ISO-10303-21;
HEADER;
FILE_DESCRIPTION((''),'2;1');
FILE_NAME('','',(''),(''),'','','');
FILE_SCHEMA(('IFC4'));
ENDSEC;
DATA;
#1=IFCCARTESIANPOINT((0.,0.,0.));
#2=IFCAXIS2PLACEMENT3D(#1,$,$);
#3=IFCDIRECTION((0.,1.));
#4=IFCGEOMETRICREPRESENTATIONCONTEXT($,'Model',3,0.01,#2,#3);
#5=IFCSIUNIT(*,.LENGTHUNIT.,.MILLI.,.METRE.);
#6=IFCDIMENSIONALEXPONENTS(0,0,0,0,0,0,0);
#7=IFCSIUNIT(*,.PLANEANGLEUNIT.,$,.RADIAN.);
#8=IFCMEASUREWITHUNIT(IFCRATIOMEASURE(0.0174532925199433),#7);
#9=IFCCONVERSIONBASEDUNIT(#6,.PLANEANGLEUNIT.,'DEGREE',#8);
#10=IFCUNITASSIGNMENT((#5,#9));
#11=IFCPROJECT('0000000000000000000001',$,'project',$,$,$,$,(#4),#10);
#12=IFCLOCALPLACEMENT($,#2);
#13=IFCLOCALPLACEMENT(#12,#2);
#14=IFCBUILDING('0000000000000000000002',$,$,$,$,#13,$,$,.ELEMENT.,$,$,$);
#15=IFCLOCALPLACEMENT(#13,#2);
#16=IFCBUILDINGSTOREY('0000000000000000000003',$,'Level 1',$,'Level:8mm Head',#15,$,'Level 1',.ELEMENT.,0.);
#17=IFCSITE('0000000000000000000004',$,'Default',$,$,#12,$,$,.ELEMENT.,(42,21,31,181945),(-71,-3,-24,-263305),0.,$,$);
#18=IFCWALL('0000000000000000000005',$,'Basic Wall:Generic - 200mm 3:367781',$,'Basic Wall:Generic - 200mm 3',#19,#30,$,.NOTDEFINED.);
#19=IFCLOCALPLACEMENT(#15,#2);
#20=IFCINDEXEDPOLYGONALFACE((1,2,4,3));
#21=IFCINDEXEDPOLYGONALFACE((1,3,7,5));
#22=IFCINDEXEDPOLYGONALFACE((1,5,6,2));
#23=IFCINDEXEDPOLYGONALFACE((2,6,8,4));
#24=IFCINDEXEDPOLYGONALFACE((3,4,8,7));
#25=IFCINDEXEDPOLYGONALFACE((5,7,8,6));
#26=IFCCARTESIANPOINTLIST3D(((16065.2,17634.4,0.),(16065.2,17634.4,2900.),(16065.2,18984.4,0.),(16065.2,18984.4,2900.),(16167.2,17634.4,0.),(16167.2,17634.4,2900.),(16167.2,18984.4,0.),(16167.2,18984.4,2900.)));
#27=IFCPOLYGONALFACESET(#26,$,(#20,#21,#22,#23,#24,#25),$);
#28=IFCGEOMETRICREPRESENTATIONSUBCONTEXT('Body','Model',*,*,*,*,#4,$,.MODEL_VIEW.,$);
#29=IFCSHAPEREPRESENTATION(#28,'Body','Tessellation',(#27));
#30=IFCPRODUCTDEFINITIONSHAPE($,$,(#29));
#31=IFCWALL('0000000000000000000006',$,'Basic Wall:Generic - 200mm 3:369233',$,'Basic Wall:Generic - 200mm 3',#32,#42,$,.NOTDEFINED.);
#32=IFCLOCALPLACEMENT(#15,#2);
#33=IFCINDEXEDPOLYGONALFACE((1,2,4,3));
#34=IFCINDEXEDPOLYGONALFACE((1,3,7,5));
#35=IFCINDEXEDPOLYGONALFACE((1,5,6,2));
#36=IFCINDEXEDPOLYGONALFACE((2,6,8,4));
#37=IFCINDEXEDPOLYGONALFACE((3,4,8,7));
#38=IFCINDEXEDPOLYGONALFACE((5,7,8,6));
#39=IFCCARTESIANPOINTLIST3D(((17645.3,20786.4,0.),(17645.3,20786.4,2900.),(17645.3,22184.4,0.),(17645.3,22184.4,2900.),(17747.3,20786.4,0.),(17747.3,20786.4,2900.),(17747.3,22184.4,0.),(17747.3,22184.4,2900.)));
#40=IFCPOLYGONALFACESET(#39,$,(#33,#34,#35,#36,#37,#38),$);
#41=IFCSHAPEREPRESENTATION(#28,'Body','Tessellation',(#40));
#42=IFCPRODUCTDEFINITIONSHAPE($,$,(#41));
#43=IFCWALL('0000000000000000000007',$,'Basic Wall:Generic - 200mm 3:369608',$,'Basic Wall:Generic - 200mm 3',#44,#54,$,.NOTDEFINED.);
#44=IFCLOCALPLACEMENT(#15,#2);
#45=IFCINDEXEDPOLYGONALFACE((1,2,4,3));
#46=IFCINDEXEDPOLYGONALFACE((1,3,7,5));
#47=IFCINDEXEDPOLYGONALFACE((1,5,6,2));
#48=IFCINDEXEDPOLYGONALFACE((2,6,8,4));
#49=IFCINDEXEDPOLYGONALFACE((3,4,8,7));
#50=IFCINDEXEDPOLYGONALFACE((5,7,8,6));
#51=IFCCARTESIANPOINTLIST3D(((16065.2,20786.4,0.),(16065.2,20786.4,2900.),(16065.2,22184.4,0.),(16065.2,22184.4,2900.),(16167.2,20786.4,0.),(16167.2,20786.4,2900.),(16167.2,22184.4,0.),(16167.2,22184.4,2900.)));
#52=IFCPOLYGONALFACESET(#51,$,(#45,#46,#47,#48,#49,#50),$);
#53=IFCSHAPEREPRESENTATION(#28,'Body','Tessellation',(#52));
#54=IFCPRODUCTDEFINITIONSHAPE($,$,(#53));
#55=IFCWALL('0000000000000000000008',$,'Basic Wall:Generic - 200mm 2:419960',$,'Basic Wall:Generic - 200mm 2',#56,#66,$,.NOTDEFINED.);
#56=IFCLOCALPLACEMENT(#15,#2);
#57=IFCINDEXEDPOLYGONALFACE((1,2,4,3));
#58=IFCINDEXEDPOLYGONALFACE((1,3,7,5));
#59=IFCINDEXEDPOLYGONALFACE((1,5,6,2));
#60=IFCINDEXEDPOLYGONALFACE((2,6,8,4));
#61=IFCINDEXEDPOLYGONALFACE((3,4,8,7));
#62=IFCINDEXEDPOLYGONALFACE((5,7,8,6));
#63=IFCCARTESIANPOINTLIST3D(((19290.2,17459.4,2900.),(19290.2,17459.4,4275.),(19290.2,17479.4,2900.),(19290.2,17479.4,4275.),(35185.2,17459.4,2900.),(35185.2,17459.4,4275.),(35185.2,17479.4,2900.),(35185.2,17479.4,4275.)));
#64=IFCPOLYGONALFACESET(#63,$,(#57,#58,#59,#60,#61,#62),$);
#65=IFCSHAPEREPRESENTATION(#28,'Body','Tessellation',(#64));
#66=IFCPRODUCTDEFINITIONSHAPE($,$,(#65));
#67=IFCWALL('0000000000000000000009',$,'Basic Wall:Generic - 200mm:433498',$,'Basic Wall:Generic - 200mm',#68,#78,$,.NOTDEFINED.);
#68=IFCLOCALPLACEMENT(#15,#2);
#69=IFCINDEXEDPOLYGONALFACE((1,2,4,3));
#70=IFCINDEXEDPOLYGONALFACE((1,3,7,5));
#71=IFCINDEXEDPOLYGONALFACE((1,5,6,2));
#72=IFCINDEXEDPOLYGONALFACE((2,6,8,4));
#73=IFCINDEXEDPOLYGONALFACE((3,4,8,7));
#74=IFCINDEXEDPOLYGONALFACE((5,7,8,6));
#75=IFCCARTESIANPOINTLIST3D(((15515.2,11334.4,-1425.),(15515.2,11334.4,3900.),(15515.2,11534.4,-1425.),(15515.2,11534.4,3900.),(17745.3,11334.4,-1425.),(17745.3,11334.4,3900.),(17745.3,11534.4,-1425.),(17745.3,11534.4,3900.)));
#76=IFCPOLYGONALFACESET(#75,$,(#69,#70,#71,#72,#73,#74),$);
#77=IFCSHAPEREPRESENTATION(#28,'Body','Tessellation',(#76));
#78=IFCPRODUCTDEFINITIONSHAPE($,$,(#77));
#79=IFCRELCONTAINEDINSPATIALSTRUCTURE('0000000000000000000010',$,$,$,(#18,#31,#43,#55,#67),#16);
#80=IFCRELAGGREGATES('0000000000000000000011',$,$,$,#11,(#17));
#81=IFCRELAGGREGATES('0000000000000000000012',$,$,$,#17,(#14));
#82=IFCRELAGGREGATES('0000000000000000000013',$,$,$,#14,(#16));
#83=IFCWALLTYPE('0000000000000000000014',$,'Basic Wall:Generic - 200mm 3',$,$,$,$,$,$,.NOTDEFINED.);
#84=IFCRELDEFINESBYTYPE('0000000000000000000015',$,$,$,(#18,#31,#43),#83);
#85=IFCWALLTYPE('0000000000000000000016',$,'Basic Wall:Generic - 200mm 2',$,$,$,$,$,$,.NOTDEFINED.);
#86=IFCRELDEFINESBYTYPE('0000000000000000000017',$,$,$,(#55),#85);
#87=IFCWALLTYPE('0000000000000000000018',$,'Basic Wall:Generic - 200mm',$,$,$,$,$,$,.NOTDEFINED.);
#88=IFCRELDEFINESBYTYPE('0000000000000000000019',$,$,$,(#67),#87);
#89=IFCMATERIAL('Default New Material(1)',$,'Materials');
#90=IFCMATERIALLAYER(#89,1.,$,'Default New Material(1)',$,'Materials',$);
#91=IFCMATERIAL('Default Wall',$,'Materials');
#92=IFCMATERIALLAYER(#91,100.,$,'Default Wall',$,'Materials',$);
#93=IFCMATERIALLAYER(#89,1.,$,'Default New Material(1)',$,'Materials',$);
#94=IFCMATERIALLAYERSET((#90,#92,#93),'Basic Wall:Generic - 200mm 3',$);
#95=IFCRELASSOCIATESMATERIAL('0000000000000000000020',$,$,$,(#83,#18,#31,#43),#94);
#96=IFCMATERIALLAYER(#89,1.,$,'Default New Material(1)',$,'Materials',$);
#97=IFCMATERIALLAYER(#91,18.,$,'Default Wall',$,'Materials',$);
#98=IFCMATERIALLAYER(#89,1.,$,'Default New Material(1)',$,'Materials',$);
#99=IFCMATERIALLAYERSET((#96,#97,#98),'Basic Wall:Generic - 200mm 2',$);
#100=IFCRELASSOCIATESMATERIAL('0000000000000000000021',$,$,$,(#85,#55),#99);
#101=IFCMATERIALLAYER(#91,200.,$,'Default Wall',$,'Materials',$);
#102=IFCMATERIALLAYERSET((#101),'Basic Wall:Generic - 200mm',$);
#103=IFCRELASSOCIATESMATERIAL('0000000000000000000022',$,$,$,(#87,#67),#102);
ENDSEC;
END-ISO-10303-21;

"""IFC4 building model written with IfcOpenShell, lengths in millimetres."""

from ifc_helpers import new_model, entity, si_unit, converted_unit, direction, frame, origin, place, context, subcontext, project, spatial, indexed_curve, outline, extrude, material, layer, layer_set, type_object, element, save


model = new_model("IFC4")

# Units and contexts
model_context = context("Model", 3, precision=0.01, world=origin(), true_north=direction((0.0, 1.0)))
body_context = subcontext(model_context, "Body", "Model", "MODEL_VIEW")
ifc_project = project(units=[si_unit("LENGTHUNIT", "METRE", prefix="MILLI"), converted_unit("PLANEANGLEUNIT", "DEGREE", entity("IfcRatioMeasure", 0.0174532925199433), si_unit("PLANEANGLEUNIT", "RADIAN"), dimensions=[0, 0, 0, 0, 0, 0, 0])], contexts=[model_context])

# Site, building, storey
site_placement = place(None, origin())
site = spatial("IfcSite", under=ifc_project, at=site_placement, Name="Default", CompositionType="ELEMENT", RefLatitude=(42, 21, 31, 181945), RefLongitude=(-71, -3, -24, -263305), RefElevation=0.0)
building_placement = place(site_placement, origin())
building = spatial("IfcBuilding", under=site, at=building_placement, CompositionType="ELEMENT")
storey_placement = place(building_placement, origin())
storey = spatial("IfcBuildingStorey", under=building, at=storey_placement, Name="Level 1", ObjectType="Level:8mm Head", LongName="Level 1", CompositionType="ELEMENT", Elevation=0.0)

# Walls
ifc_material_1 = material(Name="Default Wall", Category="Materials")
ifc_material_2 = material(Name="Default New Material(1)", Category="Materials")
ifc_layer_1 = layer(ifc_material_2, 1.0, Name="Default New Material(1)", Category="Materials")
ifc_layer_2 = layer(ifc_material_1, 100.0, Name="Default Wall", Category="Materials")
ifc_layer_3 = layer(ifc_material_2, 1.0, Name="Default New Material(1)", Category="Materials")
ifc_layer_set_1 = layer_set([ifc_layer_1, ifc_layer_2, ifc_layer_3], Name="Basic Wall:Generic - 200mm 3")
wall_type_1 = type_object("IfcWallType", Name="Basic Wall:Generic - 200mm 3", PredefinedType="NOTDEFINED", material=ifc_layer_set_1)
wall_1_placement = place(storey_placement, frame((16116.2, 17634.4, 0.0), z_axis=(0.0, 0.0, 1.0), x_axis=(0.0, 1.0, 0.0)))
element("IfcWall", 1, at=wall_1_placement, inside=storey, type_object=wall_type_1, material=ifc_layer_set_1, Name="Basic Wall:Generic - 200mm 3:367781", ObjectType="Basic Wall:Generic - 200mm 3", PredefinedType="NOTDEFINED", context=body_context, shape_type="SweptSolid", body=[
    extrude(outline(indexed_curve([(1350.0, 51.0), (0.0, 51.0), (0.0, -51.0), (1350.0, -51.0), (1350.0, 51.0)], self_intersect=False)), origin(), (0.0, 0.0, 1.0), 2900.0),
])
wall_2_placement = place(storey_placement, frame((17696.3, 20786.4, 0.0), z_axis=(0.0, 0.0, 1.0), x_axis=(0.0, 1.0, 0.0)))
element("IfcWall", 2, at=wall_2_placement, inside=storey, type_object=wall_type_1, material=ifc_layer_set_1, Name="Basic Wall:Generic - 200mm 3:369233", ObjectType="Basic Wall:Generic - 200mm 3", PredefinedType="NOTDEFINED", context=body_context, shape_type="SweptSolid", body=[
    extrude(outline(indexed_curve([(1398.0, 51.0), (0.0, 51.0), (0.0, -51.0), (1398.0, -51.0), (1398.0, 51.0)], self_intersect=False)), origin(), (0.0, 0.0, 1.0), 2900.0),
])
wall_3_placement = place(storey_placement, frame((16116.2, 20786.4, 0.0), z_axis=(0.0, 0.0, 1.0), x_axis=(0.0, 1.0, 0.0)))
element("IfcWall", 3, at=wall_3_placement, inside=storey, type_object=wall_type_1, material=ifc_layer_set_1, Name="Basic Wall:Generic - 200mm 3:369608", ObjectType="Basic Wall:Generic - 200mm 3", PredefinedType="NOTDEFINED", context=body_context, shape_type="SweptSolid", body=[
    extrude(outline(indexed_curve([(1398.0, 51.0), (0.0, 51.0), (0.0, -51.0), (1398.0, -51.0), (1398.0, 51.0)], self_intersect=False)), origin(), (0.0, 0.0, 1.0), 2900.0),
])
ifc_layer_4 = layer(ifc_material_2, 1.0, Name="Default New Material(1)", Category="Materials")
ifc_layer_5 = layer(ifc_material_1, 18.0, Name="Default Wall", Category="Materials")
ifc_layer_6 = layer(ifc_material_2, 1.0, Name="Default New Material(1)", Category="Materials")
ifc_layer_set_2 = layer_set([ifc_layer_4, ifc_layer_5, ifc_layer_6], Name="Basic Wall:Generic - 200mm 2")
wall_type_2 = type_object("IfcWallType", Name="Basic Wall:Generic - 200mm 2", PredefinedType="NOTDEFINED", material=ifc_layer_set_2)
wall_4_placement = place(storey_placement, frame((19290.2, 17469.4, 2900.0)))
element("IfcWall", 4, at=wall_4_placement, inside=storey, type_object=wall_type_2, material=ifc_layer_set_2, Name="Basic Wall:Generic - 200mm 2:419960", ObjectType="Basic Wall:Generic - 200mm 2", PredefinedType="NOTDEFINED", context=body_context, shape_type="SweptSolid", body=[
    extrude(outline(indexed_curve([(15895.0, 10.0), (0.0, 10.0), (0.0, -10.0), (15895.0, -10.0), (15895.0, 10.0)], self_intersect=False)), origin(), (0.0, 0.0, 1.0), 1375.0),
])
ifc_layer_7 = layer(ifc_material_1, 200.0, Name="Default Wall", Category="Materials")
ifc_layer_set_3 = layer_set([ifc_layer_7], Name="Basic Wall:Generic - 200mm")
wall_type_3 = type_object("IfcWallType", Name="Basic Wall:Generic - 200mm", PredefinedType="NOTDEFINED", material=ifc_layer_set_3)
wall_5_placement = place(building_placement, frame((15515.2, 11434.4, -1425.0)))
element("IfcWall", 5, at=wall_5_placement, inside=storey, type_object=wall_type_3, material=ifc_layer_set_3, Name="Basic Wall:Generic - 200mm:433498", ObjectType="Basic Wall:Generic - 200mm", PredefinedType="NOTDEFINED", context=body_context, shape_type="SweptSolid", body=[
    extrude(outline(indexed_curve([(2230.1, 100.0), (0.0, 100.0), (0.0, -100.0), (2230.1, -100.0), (2230.1, 100.0)], self_intersect=False)), origin(), (0.0, 0.0, 1.0), 5325.0),
])

save(model, "model.ifc")
